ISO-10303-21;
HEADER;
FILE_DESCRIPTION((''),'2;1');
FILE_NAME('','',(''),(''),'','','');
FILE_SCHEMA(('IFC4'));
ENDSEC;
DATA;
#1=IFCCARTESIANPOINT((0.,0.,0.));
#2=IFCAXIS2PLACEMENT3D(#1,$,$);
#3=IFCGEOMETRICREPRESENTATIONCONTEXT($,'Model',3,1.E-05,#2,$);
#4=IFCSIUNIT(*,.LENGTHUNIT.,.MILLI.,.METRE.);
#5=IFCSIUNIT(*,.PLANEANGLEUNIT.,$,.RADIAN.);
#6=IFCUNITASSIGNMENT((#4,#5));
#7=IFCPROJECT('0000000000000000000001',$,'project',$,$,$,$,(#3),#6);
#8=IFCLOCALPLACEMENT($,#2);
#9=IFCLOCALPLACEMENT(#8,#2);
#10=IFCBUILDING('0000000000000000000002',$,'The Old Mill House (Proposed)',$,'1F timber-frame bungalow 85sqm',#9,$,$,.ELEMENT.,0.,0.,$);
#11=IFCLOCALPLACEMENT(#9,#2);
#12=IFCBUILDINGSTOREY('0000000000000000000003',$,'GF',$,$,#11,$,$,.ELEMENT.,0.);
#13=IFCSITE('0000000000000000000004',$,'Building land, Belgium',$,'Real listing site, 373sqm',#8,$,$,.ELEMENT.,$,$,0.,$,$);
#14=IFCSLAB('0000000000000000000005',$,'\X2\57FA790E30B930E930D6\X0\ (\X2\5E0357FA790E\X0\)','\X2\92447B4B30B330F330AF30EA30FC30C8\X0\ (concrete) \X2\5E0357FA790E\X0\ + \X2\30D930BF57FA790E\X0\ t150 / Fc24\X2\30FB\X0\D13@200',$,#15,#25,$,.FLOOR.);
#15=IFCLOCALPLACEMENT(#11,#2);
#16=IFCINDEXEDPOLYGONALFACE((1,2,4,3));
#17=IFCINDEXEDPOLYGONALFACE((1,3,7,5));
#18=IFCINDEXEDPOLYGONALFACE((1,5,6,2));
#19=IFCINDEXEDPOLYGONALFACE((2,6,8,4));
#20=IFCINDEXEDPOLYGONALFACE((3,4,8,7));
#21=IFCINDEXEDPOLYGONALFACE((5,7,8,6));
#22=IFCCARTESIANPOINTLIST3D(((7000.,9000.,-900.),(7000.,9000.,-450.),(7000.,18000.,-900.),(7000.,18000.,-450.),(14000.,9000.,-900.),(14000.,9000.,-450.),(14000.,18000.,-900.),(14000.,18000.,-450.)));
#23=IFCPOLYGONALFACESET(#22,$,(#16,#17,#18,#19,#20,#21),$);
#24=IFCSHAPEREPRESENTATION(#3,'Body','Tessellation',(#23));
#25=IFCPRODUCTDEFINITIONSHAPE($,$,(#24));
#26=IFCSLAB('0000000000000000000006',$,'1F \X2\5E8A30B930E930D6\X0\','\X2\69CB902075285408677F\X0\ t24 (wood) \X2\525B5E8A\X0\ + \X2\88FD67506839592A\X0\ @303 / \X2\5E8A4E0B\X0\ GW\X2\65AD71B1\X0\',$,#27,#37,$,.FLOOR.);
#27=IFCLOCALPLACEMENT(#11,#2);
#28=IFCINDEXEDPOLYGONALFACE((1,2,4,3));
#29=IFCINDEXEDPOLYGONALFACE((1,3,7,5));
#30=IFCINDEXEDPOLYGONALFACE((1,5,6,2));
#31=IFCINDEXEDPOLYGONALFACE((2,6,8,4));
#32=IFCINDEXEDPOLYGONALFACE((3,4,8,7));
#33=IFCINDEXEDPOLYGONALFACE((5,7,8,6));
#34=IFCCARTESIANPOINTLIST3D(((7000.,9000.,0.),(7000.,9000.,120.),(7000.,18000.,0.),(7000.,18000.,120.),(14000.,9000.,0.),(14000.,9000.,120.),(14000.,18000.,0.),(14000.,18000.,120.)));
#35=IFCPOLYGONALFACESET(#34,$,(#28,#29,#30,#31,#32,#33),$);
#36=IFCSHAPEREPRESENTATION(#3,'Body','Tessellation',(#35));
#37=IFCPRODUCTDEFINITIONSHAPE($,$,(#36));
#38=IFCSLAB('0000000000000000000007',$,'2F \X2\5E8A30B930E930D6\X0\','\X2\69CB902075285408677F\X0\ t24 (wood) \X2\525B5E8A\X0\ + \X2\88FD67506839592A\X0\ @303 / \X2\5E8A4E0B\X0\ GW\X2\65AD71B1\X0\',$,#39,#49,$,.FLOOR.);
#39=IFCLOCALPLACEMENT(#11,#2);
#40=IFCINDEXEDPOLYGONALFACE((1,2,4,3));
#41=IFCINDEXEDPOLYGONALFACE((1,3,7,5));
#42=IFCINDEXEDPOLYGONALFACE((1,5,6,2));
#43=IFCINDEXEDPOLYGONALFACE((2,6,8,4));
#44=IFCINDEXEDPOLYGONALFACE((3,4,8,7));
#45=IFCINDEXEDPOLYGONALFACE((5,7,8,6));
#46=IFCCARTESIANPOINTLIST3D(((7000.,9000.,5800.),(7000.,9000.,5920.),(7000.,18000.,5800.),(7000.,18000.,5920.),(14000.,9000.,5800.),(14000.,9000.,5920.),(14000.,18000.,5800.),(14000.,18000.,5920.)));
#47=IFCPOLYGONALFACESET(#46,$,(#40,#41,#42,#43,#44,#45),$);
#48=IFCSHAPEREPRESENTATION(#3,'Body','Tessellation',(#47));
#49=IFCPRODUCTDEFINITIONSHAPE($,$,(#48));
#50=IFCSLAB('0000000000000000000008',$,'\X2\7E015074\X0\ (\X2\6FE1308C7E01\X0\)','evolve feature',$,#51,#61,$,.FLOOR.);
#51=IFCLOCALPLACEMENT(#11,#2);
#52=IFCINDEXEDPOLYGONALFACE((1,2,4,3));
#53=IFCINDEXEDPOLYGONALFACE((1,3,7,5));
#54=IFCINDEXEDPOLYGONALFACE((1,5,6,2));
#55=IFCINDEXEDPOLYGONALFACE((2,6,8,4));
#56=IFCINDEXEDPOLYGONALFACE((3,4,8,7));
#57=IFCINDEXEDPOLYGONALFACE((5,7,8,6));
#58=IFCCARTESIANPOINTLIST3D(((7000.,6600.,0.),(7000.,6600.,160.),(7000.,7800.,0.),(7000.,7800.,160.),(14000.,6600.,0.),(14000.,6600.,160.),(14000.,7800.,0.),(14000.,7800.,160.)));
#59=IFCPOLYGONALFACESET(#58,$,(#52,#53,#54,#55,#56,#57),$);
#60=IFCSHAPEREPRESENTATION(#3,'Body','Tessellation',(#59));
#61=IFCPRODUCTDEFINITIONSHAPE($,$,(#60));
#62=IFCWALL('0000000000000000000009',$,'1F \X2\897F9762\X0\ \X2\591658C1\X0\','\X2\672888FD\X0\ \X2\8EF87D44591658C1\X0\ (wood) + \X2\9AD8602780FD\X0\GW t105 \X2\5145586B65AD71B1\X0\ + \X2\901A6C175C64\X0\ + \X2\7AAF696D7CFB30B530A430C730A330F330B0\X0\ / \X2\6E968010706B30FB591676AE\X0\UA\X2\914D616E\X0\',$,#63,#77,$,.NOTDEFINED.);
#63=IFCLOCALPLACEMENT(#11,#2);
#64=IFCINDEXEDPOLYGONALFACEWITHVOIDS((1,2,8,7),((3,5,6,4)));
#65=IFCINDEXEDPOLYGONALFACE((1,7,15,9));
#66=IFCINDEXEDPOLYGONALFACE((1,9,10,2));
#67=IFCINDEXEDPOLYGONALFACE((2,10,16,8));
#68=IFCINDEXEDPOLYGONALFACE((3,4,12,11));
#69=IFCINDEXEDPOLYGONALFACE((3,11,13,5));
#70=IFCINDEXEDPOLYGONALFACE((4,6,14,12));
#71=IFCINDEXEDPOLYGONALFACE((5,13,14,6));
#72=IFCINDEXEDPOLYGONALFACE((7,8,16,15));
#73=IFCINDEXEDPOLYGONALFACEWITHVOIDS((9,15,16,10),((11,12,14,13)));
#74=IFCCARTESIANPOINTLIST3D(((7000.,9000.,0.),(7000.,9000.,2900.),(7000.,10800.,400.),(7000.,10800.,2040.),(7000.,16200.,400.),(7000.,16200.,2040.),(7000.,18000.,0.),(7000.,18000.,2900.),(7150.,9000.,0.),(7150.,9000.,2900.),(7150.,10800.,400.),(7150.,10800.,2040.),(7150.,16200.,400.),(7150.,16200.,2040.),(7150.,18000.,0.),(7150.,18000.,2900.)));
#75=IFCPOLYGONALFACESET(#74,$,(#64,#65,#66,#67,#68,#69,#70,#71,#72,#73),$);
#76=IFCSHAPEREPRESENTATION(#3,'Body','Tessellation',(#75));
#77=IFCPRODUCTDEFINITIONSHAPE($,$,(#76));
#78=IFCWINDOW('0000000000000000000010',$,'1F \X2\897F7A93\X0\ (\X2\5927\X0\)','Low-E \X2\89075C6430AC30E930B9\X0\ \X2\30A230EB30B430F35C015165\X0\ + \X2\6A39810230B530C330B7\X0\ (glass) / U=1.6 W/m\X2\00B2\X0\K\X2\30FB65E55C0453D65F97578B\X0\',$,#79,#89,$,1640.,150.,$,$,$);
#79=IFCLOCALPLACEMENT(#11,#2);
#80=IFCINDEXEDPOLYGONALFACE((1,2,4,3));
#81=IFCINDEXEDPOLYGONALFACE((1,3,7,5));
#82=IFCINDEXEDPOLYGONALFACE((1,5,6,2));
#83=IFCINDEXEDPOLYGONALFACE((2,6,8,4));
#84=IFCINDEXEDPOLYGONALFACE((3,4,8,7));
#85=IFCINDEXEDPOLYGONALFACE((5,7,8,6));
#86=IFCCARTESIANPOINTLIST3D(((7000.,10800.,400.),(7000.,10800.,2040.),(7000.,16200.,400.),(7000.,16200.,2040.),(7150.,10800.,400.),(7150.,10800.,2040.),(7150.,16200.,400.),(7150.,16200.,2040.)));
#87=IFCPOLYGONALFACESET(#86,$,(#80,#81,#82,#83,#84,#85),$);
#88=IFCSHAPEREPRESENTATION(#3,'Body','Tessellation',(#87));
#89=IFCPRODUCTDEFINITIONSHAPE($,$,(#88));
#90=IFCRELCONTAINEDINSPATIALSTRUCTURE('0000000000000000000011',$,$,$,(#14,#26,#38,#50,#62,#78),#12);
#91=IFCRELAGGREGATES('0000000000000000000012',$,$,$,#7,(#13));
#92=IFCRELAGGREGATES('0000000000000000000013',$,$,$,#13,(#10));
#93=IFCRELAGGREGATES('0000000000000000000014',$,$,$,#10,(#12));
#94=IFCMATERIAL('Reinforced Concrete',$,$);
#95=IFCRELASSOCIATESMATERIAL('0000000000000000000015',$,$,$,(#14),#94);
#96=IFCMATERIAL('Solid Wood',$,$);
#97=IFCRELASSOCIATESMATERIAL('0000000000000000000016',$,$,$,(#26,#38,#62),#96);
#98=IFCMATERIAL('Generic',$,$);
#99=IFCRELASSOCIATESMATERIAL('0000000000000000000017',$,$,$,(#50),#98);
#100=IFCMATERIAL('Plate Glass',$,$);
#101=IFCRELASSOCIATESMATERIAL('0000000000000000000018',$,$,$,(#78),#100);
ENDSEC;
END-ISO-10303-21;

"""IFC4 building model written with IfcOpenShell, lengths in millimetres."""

from ifc_helpers import new_model, si_unit, frame, frame_2d, origin, place, context, project, spatial, rectangle, extrude, material, element, fill, save


model = new_model("IFC4")

# Units and contexts
model_context = context("Model", 3, precision=1e-05, world=origin())
ifc_project = project(units=[si_unit("LENGTHUNIT", "METRE", prefix="MILLI"), si_unit("PLANEANGLEUNIT", "RADIAN")], contexts=[model_context])

# Site, building, storey
site_placement = place(None, origin())
site = spatial("IfcSite", under=ifc_project, at=site_placement, Name="Building land, Belgium", ObjectType="Real listing site, 373sqm", CompositionType="ELEMENT", RefElevation=0.0)
building_placement = place(site_placement, origin())
building = spatial("IfcBuilding", under=site, at=building_placement, Name="The Old Mill House (Proposed)", ObjectType="1F timber-frame bungalow 85sqm", CompositionType="ELEMENT", ElevationOfRefHeight=0.0, ElevationOfTerrain=0.0)
storey_placement = place(building_placement, origin())
storey = spatial("IfcBuildingStorey", under=building, at=storey_placement, Name="GF", CompositionType="ELEMENT", Elevation=0.0)

# Slabs
ifc_material_1 = material(Name="Reinforced Concrete")
slab_1_placement = place(storey_placement, frame((3500.0, 4500.0, -450.0)))
element("IfcSlab", 1, at=slab_1_placement, inside=storey, material=ifc_material_1, Name="基礎スラブ (布基礎)", Description="鉄筋コンクリート (concrete) 布基礎 + ベタ基礎 t150 / Fc24・D13@200", PredefinedType="FLOOR", context=model_context, shape_type="SweptSolid", body=[
    extrude(rectangle(XDim=7000.0, YDim=9000.0, at=frame_2d((3500.0, 4500.0))), frame((3500.0, 4500.0, -450.0)), (0.0, 0.0, 1.0), 450.0),
])
ifc_material_2 = material(Name="Solid Wood")
slab_2_placement = place(storey_placement, frame((3500.0, 4500.0, 0.0)))
element("IfcSlab", 2, at=slab_2_placement, inside=storey, material=ifc_material_2, Name="1F 床スラブ", Description="構造用合板 t24 (wood) 剛床 + 製材根太 @303 / 床下 GW断熱", PredefinedType="FLOOR", context=model_context, shape_type="SweptSolid", body=[
    extrude(rectangle(XDim=7000.0, YDim=9000.0, at=frame_2d((3500.0, 4500.0))), frame((3500.0, 4500.0, 0.0)), (0.0, 0.0, 1.0), 120.0),
])
slab_3_placement = place(storey_placement, frame((3500.0, 4500.0, 2900.0)))
element("IfcSlab", 3, at=slab_3_placement, inside=storey, material=ifc_material_2, Name="2F 床スラブ", Description="構造用合板 t24 (wood) 剛床 + 製材根太 @303 / 床下 GW断熱", PredefinedType="FLOOR", context=model_context, shape_type="SweptSolid", body=[
    extrude(rectangle(XDim=7000.0, YDim=9000.0, at=frame_2d((3500.0, 4500.0))), frame((3500.0, 4500.0, 2900.0)), (0.0, 0.0, 1.0), 120.0),
])
ifc_material_3 = material(Name="Generic")
slab_4_placement = place(storey_placement, frame((3500.0, 3300.0, 0.0)))
element("IfcSlab", 4, at=slab_4_placement, inside=storey, material=ifc_material_3, Name="縁側 (濡れ縁)", Description="evolve feature", PredefinedType="FLOOR", context=model_context, shape_type="SweptSolid", body=[
    extrude(rectangle(XDim=7000.0, YDim=1200.0, at=frame_2d((3500.0, 600.0))), frame((3500.0, 3300.0, 0.0)), (0.0, 0.0, 1.0), 160.0),
])

# Shared definitions
ifc_material_4 = material(Name="Plate Glass")

# Wall, opening, window
wall_1_placement = place(storey_placement, frame((3500.0, 4500.0, 0.0)))
wall_1 = element("IfcWall", 5, at=wall_1_placement, inside=storey, material=ifc_material_2, Name="1F 西面 外壁", Description="木製 軸組外壁 (wood) + 高性能GW t105 充填断熱 + 通気層 + 窯業系サイディング / 準耐火・外皮UA配慮", PredefinedType="NOTDEFINED", context=model_context, shape_type="SweptSolid", body=[
    extrude(rectangle(XDim=150.0, YDim=9000.0, at=frame_2d((75.0, 4500.0))), frame((3500.0, 4500.0, 0.0)), (0.0, 0.0, 1.0), 2900.0),
])
opening_1_placement = place(storey_placement, frame((3500.0, 5400.0, 200.0)))
opening_1 = element("IfcOpeningElement", 6, at=opening_1_placement, cuts=wall_1, PredefinedType="NOTDEFINED", context=model_context, shape_type="SweptSolid", body=[
    extrude(rectangle(XDim=150.0, YDim=5400.0, at=frame_2d((75.0, 2700.0))), frame((3500.0, 5400.0, 200.0)), (0.0, 0.0, 1.0), 1640.0),
])
window_1_placement = place(storey_placement, frame((3500.0, 5400.0, 200.0)))
window_1 = element("IfcWindow", 7, at=window_1_placement, inside=storey, material=ifc_material_4, Name="1F 西窓 (大)", Description="Low-E 複層ガラス アルゴン封入 + 樹脂サッシ (glass) / U=1.6 W/m²K・日射取得型", OverallHeight=1640.0, OverallWidth=150.0, context=model_context, shape_type="SweptSolid", body=[
    extrude(rectangle(XDim=150.0, YDim=5400.0, at=frame_2d((75.0, 2700.0))), frame((3500.0, 5400.0, 200.0)), (0.0, 0.0, 1.0), 1640.0),
])
fill(opening_1, window_1)

save(model, "model.ifc")
